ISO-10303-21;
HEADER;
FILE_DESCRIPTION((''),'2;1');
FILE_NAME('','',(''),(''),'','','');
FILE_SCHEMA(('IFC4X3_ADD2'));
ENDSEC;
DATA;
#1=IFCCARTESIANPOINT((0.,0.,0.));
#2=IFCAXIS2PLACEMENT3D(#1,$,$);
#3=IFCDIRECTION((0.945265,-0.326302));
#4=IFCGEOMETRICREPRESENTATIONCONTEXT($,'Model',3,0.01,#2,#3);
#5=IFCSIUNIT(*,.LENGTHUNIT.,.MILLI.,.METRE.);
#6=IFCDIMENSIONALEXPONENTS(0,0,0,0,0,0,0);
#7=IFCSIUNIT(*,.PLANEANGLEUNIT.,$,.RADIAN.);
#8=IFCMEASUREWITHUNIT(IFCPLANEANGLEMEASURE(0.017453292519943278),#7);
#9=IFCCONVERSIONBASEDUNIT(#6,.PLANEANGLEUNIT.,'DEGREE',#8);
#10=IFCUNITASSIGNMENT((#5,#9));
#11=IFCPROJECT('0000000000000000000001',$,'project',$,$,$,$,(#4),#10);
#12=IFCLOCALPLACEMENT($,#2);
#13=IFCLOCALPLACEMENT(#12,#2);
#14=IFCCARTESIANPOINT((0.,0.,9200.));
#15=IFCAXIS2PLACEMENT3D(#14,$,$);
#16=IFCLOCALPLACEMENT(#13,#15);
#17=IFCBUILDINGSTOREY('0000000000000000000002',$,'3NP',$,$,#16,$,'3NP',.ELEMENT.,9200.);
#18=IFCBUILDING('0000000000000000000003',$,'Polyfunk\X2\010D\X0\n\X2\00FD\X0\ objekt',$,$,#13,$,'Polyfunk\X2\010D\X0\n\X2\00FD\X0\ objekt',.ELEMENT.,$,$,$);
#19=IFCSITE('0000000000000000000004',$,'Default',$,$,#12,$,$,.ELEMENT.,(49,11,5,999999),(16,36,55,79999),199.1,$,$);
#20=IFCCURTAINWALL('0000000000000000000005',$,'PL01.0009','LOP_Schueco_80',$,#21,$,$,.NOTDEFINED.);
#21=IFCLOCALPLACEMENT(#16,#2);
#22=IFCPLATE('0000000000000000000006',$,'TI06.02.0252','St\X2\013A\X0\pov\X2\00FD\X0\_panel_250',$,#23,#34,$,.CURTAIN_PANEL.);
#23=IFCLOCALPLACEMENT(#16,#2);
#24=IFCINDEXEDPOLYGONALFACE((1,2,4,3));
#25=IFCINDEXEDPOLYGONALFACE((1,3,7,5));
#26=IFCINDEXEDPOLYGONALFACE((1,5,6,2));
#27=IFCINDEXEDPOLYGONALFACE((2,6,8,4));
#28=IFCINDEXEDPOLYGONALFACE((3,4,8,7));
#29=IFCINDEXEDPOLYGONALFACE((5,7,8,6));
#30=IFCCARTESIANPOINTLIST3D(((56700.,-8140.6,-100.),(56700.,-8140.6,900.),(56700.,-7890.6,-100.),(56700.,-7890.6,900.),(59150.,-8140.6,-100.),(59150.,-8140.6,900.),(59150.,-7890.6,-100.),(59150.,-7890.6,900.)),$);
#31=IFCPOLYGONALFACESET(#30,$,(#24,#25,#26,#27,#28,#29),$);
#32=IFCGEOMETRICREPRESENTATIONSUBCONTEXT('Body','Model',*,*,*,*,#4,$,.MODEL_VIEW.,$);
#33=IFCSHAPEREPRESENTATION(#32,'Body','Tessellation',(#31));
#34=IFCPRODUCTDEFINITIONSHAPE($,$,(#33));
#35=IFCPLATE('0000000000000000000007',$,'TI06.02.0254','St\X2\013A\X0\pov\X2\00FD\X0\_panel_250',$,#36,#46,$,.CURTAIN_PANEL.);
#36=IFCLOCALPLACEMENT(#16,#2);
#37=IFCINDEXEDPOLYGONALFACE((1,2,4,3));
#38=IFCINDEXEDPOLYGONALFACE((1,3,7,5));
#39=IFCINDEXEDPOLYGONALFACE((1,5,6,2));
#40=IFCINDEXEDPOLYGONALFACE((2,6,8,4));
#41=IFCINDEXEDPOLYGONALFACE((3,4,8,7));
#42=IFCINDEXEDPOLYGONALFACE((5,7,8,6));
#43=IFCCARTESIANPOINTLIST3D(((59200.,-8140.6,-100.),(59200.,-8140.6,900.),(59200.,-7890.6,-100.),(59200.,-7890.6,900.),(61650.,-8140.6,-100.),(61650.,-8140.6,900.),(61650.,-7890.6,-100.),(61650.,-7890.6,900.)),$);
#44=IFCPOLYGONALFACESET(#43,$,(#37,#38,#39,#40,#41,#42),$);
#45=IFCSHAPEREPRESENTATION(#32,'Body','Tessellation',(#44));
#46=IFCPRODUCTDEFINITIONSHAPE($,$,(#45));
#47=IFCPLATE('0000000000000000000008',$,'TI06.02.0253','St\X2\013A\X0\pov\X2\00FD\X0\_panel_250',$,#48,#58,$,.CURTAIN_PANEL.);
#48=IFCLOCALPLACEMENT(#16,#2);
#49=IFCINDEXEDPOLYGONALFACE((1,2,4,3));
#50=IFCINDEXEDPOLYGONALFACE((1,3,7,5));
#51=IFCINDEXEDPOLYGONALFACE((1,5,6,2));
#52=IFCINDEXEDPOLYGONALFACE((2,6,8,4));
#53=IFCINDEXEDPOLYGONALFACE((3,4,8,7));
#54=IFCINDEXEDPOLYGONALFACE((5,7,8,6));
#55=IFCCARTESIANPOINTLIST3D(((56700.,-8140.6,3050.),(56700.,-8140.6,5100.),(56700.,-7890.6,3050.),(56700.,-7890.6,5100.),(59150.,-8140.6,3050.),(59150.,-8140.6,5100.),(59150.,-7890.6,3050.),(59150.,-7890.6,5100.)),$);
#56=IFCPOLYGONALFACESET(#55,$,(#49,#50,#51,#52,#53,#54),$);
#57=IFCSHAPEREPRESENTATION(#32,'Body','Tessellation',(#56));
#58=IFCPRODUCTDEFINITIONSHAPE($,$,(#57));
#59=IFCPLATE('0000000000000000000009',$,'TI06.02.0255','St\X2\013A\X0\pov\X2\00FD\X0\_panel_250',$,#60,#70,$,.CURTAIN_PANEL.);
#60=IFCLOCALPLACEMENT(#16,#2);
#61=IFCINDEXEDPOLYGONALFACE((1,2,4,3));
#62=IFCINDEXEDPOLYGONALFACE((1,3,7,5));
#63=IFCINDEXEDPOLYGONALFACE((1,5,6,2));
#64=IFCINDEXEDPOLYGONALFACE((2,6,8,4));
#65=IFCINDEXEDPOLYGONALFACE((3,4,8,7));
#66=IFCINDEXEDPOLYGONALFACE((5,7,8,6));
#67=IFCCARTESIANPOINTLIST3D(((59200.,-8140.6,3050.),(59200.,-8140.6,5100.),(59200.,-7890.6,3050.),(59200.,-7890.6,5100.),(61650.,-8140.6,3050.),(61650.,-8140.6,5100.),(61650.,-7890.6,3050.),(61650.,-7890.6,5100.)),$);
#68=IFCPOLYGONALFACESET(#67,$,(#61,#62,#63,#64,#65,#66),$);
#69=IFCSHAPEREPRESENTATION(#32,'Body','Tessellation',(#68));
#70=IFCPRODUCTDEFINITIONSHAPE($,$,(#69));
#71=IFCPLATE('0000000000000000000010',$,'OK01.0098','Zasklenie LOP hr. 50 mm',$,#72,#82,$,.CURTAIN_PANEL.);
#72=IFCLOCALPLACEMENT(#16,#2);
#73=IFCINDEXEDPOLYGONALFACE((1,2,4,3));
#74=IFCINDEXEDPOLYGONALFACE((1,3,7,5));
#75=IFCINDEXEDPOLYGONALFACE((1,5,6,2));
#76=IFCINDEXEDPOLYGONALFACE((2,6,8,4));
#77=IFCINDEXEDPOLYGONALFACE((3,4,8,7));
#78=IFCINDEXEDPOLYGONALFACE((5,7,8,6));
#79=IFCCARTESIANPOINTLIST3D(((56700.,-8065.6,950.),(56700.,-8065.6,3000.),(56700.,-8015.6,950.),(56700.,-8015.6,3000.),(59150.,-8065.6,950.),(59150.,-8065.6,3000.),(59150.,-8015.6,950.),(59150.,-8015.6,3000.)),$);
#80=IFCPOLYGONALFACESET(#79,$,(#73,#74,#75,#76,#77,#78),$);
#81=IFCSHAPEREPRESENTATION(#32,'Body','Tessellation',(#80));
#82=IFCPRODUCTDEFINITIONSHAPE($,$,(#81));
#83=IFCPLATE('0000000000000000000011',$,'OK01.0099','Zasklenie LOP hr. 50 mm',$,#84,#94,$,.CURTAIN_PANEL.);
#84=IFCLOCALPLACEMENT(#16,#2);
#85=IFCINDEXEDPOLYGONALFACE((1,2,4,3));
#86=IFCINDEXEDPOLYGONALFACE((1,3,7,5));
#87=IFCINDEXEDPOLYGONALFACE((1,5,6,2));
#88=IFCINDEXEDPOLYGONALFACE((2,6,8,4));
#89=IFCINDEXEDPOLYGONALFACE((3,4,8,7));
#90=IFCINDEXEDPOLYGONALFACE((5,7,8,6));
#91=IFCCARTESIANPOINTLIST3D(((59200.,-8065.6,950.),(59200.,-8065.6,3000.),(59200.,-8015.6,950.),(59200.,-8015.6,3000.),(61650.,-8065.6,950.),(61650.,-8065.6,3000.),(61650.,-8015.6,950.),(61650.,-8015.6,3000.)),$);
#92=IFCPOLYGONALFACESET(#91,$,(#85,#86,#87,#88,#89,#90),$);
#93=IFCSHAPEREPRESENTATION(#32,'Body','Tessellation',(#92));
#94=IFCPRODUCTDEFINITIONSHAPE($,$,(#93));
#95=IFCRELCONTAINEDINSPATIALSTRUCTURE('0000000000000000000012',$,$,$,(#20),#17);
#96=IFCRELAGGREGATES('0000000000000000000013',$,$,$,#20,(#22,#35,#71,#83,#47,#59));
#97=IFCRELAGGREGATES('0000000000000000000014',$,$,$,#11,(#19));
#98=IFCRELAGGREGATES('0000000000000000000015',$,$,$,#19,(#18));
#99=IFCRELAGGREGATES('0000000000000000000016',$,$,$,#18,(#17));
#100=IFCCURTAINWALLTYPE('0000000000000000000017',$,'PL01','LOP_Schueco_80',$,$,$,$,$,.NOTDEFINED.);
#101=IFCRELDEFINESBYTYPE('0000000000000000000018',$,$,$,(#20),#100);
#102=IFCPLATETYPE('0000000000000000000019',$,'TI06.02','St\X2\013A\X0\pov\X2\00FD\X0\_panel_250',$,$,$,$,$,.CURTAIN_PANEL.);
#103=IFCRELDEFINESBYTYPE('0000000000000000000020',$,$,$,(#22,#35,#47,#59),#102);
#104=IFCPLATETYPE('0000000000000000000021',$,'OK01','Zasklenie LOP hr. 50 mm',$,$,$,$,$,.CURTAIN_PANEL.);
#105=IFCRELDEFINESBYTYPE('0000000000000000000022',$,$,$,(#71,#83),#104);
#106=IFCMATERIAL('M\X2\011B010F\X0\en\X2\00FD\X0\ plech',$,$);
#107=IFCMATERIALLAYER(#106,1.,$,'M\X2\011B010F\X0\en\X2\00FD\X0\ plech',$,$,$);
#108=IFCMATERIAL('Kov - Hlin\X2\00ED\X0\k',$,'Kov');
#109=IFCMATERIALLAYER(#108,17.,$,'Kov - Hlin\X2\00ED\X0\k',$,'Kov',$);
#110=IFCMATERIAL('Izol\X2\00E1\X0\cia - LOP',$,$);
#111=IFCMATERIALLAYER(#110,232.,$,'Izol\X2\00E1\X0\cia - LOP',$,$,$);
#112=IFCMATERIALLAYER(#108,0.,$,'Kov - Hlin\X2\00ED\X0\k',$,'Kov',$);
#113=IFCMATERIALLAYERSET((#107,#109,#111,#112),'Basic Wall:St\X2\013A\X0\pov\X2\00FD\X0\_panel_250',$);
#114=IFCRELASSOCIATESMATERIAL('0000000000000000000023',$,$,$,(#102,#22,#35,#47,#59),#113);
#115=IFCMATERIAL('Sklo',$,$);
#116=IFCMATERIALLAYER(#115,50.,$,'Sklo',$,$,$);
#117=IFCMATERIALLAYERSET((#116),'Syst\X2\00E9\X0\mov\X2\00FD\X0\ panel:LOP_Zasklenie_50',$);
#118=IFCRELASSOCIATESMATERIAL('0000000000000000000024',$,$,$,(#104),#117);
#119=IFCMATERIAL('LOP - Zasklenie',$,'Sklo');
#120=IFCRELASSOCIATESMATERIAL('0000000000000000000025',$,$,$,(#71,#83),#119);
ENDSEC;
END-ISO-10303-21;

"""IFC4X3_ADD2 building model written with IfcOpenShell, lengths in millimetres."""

from ifc_helpers import new_model, entity, si_unit, converted_unit, direction, frame, frame_2d, origin, origin_2d_with_axis, place, context, subcontext, project, spatial, rectangle, extrude, source, transform, mapped, material, layer, layer_set, layer_usage, type_object, type_shapes, element, aggregate, save


model = new_model("IFC4X3_ADD2")

# Units and contexts
model_context = context("Model", 3, precision=0.01, world=origin(), true_north=direction((0.945265, -0.326302)))
body_context = subcontext(model_context, "Body", "Model", "MODEL_VIEW")
ifc_project = project(units=[si_unit("LENGTHUNIT", "METRE", prefix="MILLI"), converted_unit("PLANEANGLEUNIT", "DEGREE", entity("IfcPlaneAngleMeasure", 0.017453292519943278), si_unit("PLANEANGLEUNIT", "RADIAN"), dimensions=[0, 0, 0, 0, 0, 0, 0])], contexts=[model_context])

# Site, building, storey
site_placement = place(None, origin())
site = spatial("IfcSite", under=ifc_project, at=site_placement, Name="Default", CompositionType="ELEMENT", RefLatitude=(49, 11, 5, 999999), RefLongitude=(16, 36, 55, 79999), RefElevation=199.1)
building_placement = place(site_placement, origin())
building = spatial("IfcBuilding", under=site, at=building_placement, Name="Polyfunkčný objekt", LongName="Polyfunkčný objekt", CompositionType="ELEMENT")
storey_placement = place(building_placement, frame((0.0, 0.0, 9200.0)))
storey = spatial("IfcBuildingStorey", under=building, at=storey_placement, Name="3NP", LongName="3NP", CompositionType="ELEMENT", Elevation=9200.0)

# Curtain wall, plates
curtain_wall_type = type_object("IfcCurtainWallType", Name="PL01", Description="LOP_Schueco_80", PredefinedType="NOTDEFINED")
curtain_wall_placement = place(storey_placement, frame((0.0, 0.0, -9200.0)))
curtain_wall = element("IfcCurtainWall", 1, at=curtain_wall_placement, inside=storey, type_object=curtain_wall_type, Name="PL01.0009", Description="LOP_Schueco_80", PredefinedType="NOTDEFINED")
ifc_material_1 = material(Name="Měďený plech")
ifc_layer_1 = layer(ifc_material_1, 1.0, Name="Měďený plech")
ifc_material_2 = material(Name="Kov - Hliník", Category="Kov")
ifc_layer_2 = layer(ifc_material_2, 17.0, Name="Kov - Hliník", Category="Kov")
ifc_material_3 = material(Name="Izolácia - LOP")
ifc_layer_3 = layer(ifc_material_3, 232.0, Name="Izolácia - LOP")
ifc_layer_4 = layer(ifc_material_2, 0.0, Name="Kov - Hliník", Category="Kov")
ifc_layer_set_1 = layer_set([ifc_layer_1, ifc_layer_2, ifc_layer_3, ifc_layer_4], Name="Basic Wall:Stĺpový_panel_250")
ifc_layer_usage_1 = layer_usage(ifc_layer_set_1, "AXIS2", "POSITIVE", -125.0)
plate_type_1 = type_object("IfcPlateType", Name="TI06.02", Description="Stĺpový_panel_250", PredefinedType="CURTAIN_PANEL", material=ifc_layer_set_1)
plate_1_placement = place(storey_placement, frame((56700.0, -8015.6, -100.0)))
plate_1 = element("IfcPlate", 2, at=plate_1_placement, type_object=plate_type_1, material=ifc_layer_usage_1, Name="TI06.02.0252", Description="Stĺpový_panel_250", PredefinedType="CURTAIN_PANEL", context=body_context, shape_type="SweptSolid", body=[
    extrude(rectangle(XDim=250.0, YDim=2450.0, at=frame_2d((0.0, 0.0), x_axis=(1.0, 0.0))), frame((1225.0, 0.0, 0.0), z_axis=(0.0, 0.0, 1.0), x_axis=(0.0, 1.0, 0.0)), (0.0, 0.0, 1.0), 1000.0),
])
ifc_layer_usage_2 = layer_usage(ifc_layer_set_1, "AXIS2", "POSITIVE", -125.0)
plate_2_placement = place(storey_placement, frame((59200.0, -8015.6, -100.0)))
plate_2 = element("IfcPlate", 3, at=plate_2_placement, type_object=plate_type_1, material=ifc_layer_usage_2, Name="TI06.02.0254", Description="Stĺpový_panel_250", PredefinedType="CURTAIN_PANEL", context=body_context, shape_type="SweptSolid", body=[
    extrude(rectangle(XDim=250.0, YDim=2450.0, at=frame_2d((0.0, 0.0), x_axis=(1.0, 0.0))), frame((1225.0, 0.0, 0.0), z_axis=(0.0, 0.0, 1.0), x_axis=(0.0, 1.0, 0.0)), (0.0, 0.0, 1.0), 1000.0),
])
ifc_layer_usage_3 = layer_usage(ifc_layer_set_1, "AXIS2", "POSITIVE", -125.0)
plate_3_placement = place(storey_placement, frame((56700.0, -8015.6, 3050.0)))
plate_3 = element("IfcPlate", 4, at=plate_3_placement, type_object=plate_type_1, material=ifc_layer_usage_3, Name="TI06.02.0253", Description="Stĺpový_panel_250", PredefinedType="CURTAIN_PANEL", context=body_context, shape_type="SweptSolid", body=[
    extrude(rectangle(XDim=250.0, YDim=2450.0, at=frame_2d((0.0, 0.0), x_axis=(1.0, 0.0))), frame((1225.0, 0.0, 0.0), z_axis=(0.0, 0.0, 1.0), x_axis=(0.0, 1.0, 0.0)), (0.0, 0.0, 1.0), 2050.0),
])
ifc_layer_usage_4 = layer_usage(ifc_layer_set_1, "AXIS2", "POSITIVE", -125.0)
plate_4_placement = place(storey_placement, frame((59200.0, -8015.6, 3050.0)))
plate_4 = element("IfcPlate", 5, at=plate_4_placement, type_object=plate_type_1, material=ifc_layer_usage_4, Name="TI06.02.0255", Description="Stĺpový_panel_250", PredefinedType="CURTAIN_PANEL", context=body_context, shape_type="SweptSolid", body=[
    extrude(rectangle(XDim=250.0, YDim=2450.0, at=frame_2d((0.0, 0.0), x_axis=(1.0, 0.0))), frame((1225.0, 0.0, 0.0), z_axis=(0.0, 0.0, 1.0), x_axis=(0.0, 1.0, 0.0)), (0.0, 0.0, 1.0), 2050.0),
])
ifc_material_4 = material(Name="LOP - Zasklenie", Category="Sklo")
ifc_material_5 = material(Name="Sklo")
ifc_layer_5 = layer(ifc_material_5, 50.0, Name="Sklo")
ifc_layer_set_2 = layer_set([ifc_layer_5], Name="Systémový panel:LOP_Zasklenie_50")
plate_type_2 = type_object("IfcPlateType", Name="OK01", Description="Zasklenie LOP hr. 50 mm", PredefinedType="CURTAIN_PANEL", material=ifc_layer_set_2)
shared_shape_1 = source(origin(), body_context, "Body", "SweptSolid", [
    extrude(rectangle(XDim=50.0, YDim=2450.0, at=origin_2d_with_axis()), frame((0.0, -25.0, 0.0), z_axis=(0.0, 0.0, 1.0), x_axis=(0.0, 1.0, 0.0)), (0.0, 0.0, 1.0), 2050.0),
])
type_shapes(plate_type_2, [shared_shape_1])
plate_5_placement = place(curtain_wall_placement, frame((57925.0, -8015.6, 10150.0)))
plate_5 = element("IfcPlate", 6, at=plate_5_placement, type_object=plate_type_2, material=ifc_material_4, Name="OK01.0098", Description="Zasklenie LOP hr. 50 mm", PredefinedType="CURTAIN_PANEL", context=body_context, shape_type="MappedRepresentation", body=[
    mapped(shared_shape_1, transform((0.0, 0.0, 0.0), scale=1.0)),
])
plate_6_placement = place(curtain_wall_placement, frame((60425.0, -8015.6, 10150.0)))
plate_6 = element("IfcPlate", 7, at=plate_6_placement, type_object=plate_type_2, material=ifc_material_4, Name="OK01.0099", Description="Zasklenie LOP hr. 50 mm", PredefinedType="CURTAIN_PANEL", context=body_context, shape_type="MappedRepresentation", body=[
    mapped(shared_shape_1, transform((0.0, 0.0, 0.0), scale=1.0)),
])
aggregate(curtain_wall, [plate_1, plate_2, plate_5, plate_6, plate_3, plate_4])

save(model, "model.ifc")
